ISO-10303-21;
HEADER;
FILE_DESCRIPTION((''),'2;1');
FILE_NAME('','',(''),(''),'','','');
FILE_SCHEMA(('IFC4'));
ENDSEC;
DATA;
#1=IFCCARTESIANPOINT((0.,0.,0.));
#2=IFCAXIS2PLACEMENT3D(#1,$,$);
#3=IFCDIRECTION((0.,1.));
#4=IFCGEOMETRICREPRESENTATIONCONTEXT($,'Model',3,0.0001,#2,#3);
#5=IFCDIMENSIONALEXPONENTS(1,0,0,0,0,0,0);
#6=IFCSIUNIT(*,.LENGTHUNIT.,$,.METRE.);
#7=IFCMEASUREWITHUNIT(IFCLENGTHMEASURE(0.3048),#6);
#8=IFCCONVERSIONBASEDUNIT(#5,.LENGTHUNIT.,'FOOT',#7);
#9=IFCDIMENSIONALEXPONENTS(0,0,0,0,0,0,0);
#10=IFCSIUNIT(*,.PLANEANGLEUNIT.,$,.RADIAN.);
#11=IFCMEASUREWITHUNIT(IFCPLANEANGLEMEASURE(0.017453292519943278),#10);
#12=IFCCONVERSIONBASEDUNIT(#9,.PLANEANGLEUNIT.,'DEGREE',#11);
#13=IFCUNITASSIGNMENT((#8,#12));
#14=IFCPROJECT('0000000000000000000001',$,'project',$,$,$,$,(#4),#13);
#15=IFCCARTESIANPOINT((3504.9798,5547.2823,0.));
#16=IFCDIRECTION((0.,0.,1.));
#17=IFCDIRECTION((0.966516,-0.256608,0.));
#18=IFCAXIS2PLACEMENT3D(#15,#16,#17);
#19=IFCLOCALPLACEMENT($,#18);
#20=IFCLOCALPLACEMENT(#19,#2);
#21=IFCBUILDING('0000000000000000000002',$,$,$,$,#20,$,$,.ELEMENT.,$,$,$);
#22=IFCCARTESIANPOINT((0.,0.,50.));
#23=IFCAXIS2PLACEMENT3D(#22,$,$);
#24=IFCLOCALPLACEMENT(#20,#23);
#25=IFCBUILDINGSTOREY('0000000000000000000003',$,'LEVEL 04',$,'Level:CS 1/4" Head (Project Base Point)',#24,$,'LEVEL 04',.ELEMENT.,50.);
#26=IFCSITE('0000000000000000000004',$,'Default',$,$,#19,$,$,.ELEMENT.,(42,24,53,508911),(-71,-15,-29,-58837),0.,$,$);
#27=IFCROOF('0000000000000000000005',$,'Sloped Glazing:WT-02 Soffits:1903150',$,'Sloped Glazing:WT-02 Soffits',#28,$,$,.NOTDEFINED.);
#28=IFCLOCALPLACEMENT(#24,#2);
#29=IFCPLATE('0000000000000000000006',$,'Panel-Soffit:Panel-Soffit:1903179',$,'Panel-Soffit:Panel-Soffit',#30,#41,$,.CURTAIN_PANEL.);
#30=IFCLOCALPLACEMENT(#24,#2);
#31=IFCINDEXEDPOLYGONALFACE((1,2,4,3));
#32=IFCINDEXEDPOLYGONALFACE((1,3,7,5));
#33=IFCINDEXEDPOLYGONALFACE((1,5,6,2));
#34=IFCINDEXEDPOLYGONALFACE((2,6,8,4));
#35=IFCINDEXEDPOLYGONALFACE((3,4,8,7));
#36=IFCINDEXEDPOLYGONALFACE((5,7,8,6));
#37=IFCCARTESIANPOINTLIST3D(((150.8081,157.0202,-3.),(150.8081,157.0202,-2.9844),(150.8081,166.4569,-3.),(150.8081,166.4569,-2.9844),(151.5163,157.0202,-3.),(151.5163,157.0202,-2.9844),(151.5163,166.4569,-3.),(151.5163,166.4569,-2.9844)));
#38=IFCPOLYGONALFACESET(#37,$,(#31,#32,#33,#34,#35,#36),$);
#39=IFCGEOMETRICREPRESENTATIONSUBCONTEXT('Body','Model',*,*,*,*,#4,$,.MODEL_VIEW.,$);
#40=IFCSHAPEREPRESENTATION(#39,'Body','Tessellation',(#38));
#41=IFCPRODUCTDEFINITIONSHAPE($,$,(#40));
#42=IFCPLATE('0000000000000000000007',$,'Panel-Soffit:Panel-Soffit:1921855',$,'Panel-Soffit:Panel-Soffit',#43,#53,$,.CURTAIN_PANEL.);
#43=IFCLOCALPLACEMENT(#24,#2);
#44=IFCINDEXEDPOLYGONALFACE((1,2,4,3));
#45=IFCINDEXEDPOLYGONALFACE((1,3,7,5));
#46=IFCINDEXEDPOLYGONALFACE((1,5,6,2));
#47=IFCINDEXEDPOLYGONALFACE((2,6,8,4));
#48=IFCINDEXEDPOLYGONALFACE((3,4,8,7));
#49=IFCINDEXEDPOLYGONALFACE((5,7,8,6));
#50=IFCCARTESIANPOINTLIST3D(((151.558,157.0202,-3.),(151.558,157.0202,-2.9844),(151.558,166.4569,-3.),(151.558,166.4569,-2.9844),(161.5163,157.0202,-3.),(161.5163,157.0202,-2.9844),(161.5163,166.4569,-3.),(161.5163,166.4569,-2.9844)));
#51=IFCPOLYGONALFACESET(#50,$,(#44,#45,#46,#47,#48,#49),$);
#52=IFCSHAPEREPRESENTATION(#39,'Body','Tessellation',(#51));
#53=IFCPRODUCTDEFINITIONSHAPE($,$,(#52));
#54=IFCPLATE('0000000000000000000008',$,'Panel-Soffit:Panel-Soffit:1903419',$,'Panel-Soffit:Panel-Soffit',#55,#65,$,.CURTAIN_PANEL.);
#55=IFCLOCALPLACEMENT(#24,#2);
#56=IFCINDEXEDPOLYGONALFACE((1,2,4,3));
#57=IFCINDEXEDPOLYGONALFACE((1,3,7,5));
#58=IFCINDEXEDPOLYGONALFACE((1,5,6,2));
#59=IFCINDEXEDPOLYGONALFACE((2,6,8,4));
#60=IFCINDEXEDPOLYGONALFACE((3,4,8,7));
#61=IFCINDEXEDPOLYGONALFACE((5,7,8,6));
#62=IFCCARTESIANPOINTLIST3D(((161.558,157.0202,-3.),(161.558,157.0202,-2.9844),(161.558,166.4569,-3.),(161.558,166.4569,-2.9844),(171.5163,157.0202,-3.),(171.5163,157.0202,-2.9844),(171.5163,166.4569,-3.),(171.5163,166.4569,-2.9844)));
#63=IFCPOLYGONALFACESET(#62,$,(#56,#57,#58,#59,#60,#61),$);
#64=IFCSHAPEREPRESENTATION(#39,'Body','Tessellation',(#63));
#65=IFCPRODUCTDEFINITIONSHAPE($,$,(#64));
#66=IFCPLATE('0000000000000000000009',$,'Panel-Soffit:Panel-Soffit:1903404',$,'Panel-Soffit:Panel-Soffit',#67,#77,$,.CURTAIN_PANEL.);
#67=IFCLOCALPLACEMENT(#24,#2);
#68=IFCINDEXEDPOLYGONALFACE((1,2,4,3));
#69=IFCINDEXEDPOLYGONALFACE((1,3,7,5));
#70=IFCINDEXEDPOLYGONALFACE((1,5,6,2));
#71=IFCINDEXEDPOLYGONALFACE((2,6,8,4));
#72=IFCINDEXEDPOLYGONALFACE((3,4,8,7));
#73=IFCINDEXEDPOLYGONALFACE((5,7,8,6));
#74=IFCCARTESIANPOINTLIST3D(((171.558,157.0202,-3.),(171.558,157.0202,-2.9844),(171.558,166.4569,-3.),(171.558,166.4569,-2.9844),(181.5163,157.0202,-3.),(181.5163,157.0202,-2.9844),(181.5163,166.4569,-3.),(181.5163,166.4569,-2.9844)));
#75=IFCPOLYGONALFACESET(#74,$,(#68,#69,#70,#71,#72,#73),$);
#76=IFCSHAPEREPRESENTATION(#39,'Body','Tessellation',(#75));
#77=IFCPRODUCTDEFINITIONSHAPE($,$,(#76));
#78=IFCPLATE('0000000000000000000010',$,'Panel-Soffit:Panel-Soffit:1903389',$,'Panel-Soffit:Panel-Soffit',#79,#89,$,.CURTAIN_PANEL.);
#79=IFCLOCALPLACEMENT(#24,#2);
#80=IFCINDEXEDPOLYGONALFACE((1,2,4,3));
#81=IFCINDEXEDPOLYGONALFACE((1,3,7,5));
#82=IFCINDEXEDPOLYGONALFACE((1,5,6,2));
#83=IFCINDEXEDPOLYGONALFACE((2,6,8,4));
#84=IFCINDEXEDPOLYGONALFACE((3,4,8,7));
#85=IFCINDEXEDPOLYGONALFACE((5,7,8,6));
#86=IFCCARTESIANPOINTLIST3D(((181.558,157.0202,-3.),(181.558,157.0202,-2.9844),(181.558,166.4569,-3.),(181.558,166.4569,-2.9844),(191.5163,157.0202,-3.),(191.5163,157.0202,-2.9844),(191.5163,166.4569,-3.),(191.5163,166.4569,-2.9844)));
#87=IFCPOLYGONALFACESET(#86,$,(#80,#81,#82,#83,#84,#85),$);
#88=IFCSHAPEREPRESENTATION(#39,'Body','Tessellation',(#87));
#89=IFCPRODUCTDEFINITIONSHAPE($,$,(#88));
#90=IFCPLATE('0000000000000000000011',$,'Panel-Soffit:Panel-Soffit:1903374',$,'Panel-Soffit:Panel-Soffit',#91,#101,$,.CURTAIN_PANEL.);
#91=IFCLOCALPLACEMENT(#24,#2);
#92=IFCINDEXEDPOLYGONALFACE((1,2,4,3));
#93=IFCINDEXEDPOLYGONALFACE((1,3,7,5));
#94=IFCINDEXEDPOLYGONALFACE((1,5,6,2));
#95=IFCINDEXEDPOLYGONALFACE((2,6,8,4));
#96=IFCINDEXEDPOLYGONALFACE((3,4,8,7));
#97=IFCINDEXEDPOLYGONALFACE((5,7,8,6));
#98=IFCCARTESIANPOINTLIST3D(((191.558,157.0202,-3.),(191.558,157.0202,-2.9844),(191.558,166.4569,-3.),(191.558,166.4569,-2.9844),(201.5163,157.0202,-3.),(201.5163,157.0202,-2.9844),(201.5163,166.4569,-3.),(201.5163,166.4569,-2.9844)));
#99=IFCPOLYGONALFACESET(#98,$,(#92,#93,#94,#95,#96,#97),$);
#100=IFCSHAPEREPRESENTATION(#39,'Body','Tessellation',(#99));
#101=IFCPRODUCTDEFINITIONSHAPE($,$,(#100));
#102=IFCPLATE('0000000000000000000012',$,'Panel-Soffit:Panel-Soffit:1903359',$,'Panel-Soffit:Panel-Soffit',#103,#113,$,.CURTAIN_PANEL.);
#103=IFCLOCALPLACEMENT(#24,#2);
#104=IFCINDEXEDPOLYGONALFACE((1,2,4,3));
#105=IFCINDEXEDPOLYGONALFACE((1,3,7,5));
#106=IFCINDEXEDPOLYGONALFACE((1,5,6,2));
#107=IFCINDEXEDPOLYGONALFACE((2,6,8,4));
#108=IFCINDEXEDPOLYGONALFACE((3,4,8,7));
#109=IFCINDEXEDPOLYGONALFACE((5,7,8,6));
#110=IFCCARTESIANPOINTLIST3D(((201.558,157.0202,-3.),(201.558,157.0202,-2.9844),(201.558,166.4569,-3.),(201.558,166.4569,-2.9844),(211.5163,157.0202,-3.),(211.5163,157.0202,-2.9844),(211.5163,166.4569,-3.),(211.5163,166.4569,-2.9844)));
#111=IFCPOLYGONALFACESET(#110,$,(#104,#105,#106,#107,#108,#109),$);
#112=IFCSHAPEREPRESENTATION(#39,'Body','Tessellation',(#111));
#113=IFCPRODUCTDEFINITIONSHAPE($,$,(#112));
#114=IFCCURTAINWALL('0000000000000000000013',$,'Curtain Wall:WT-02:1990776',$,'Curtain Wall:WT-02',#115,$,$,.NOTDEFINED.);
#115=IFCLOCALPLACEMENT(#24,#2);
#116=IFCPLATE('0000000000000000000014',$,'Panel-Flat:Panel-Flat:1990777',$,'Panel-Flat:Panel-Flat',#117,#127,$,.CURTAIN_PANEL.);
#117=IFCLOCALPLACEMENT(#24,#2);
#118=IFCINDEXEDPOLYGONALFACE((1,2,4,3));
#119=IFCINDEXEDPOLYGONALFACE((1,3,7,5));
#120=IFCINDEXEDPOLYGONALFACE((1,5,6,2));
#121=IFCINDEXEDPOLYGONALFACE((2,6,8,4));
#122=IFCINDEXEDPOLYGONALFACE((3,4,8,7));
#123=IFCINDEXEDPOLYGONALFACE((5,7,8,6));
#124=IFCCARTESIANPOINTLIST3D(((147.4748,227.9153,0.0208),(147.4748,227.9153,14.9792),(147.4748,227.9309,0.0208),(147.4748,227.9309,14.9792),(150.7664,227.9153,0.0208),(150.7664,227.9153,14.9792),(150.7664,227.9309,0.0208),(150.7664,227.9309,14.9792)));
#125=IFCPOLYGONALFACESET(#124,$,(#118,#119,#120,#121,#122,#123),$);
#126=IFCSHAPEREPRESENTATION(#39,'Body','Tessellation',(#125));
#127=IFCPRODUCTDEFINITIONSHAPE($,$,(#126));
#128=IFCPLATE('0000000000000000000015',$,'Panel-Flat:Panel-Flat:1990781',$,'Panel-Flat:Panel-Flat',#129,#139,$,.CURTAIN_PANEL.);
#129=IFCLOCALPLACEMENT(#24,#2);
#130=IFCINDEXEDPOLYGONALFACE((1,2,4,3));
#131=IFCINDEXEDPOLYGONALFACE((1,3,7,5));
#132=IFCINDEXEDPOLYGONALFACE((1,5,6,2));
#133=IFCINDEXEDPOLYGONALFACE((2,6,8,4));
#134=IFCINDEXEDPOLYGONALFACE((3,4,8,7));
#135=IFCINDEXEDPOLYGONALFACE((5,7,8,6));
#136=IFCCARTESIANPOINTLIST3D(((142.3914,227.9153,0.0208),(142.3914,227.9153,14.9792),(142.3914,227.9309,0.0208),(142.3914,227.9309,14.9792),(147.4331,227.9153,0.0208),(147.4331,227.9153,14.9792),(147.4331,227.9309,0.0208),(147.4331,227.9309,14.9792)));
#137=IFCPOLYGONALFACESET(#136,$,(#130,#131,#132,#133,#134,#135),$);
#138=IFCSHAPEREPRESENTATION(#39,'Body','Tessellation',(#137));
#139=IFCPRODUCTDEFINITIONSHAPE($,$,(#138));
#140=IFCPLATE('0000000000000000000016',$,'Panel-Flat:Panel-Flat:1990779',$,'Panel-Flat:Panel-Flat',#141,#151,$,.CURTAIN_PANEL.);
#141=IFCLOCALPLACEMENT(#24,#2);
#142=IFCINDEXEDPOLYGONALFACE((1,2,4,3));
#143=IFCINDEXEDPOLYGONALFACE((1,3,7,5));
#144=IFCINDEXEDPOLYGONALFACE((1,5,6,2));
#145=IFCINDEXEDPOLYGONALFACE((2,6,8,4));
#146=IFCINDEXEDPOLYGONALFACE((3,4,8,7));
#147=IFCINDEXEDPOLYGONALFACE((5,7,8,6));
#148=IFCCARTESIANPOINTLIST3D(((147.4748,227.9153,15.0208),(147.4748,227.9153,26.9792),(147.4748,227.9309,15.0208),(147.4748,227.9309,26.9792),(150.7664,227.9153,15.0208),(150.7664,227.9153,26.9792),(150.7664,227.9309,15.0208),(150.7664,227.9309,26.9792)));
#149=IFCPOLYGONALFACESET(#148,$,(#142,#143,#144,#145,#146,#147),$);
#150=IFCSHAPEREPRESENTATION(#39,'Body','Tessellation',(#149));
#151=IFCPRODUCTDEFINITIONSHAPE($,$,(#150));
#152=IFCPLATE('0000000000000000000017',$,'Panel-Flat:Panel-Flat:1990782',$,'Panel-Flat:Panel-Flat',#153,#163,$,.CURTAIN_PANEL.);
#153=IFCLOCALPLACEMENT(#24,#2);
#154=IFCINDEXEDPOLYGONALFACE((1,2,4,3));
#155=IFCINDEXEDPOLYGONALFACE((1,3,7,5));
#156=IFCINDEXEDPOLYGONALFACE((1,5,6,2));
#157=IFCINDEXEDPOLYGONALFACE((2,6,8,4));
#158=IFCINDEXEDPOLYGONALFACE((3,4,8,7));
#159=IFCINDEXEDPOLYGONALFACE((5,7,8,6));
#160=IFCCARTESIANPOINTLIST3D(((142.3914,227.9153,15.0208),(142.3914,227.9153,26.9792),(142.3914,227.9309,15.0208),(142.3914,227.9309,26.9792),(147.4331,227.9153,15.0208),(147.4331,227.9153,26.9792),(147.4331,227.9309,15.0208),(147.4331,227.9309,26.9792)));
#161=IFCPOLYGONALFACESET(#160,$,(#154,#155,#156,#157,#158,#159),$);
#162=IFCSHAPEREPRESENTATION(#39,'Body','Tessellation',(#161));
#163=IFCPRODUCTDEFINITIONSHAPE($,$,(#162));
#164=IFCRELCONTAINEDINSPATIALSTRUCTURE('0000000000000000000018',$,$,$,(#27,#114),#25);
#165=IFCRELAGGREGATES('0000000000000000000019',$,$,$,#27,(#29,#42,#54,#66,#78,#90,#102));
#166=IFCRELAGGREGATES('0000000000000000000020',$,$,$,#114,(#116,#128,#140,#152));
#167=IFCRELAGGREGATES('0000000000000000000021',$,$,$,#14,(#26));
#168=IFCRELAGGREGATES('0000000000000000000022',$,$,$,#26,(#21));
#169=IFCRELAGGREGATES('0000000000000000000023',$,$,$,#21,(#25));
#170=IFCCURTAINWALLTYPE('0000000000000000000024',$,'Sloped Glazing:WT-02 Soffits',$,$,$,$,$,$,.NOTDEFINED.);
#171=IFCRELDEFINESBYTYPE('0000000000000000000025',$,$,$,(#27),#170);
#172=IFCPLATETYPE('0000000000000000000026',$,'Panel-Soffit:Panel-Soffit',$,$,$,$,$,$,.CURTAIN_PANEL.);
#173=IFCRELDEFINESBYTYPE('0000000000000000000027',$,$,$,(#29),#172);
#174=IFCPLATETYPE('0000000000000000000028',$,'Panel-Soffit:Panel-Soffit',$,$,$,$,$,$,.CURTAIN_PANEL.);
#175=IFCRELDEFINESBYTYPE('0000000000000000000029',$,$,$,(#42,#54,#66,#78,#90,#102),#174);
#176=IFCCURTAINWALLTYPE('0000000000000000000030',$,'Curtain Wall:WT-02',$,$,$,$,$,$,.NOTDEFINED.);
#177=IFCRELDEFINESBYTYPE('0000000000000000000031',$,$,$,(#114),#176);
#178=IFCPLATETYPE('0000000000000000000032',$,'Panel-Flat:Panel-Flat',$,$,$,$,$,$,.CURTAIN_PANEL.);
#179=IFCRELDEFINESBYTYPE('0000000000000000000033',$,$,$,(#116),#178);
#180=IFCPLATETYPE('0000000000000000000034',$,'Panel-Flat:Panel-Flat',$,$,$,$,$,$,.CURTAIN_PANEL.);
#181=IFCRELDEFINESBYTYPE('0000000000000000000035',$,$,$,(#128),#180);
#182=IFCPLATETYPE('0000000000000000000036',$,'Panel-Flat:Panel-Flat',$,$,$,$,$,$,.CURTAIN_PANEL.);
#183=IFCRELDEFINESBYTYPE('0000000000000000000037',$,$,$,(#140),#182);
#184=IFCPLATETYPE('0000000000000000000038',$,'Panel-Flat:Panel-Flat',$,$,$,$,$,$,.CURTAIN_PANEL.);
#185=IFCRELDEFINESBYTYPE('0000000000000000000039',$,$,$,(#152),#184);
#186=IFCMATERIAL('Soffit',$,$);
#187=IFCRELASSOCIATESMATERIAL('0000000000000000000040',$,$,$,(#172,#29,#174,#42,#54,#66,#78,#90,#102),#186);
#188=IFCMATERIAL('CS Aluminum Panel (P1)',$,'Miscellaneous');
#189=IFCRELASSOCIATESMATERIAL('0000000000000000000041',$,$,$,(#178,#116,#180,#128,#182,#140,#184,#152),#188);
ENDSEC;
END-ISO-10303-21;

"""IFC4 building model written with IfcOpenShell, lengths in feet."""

from ifc_helpers import new_model, entity, si_unit, converted_unit, direction, frame, origin, place, context, subcontext, project, spatial, indexed_curve, outline, extrude, source, transform, mapped, material, type_object, type_shapes, element, aggregate, save


model = new_model("IFC4")

# Units and contexts
model_context = context("Model", 3, precision=0.0001, world=origin(), true_north=direction((0.0, 1.0)))
body_context = subcontext(model_context, "Body", "Model", "MODEL_VIEW")
ifc_project = project(units=[converted_unit("LENGTHUNIT", "FOOT", entity("IfcLengthMeasure", 0.3048), si_unit("LENGTHUNIT", "METRE"), dimensions=[1, 0, 0, 0, 0, 0, 0]), converted_unit("PLANEANGLEUNIT", "DEGREE", entity("IfcPlaneAngleMeasure", 0.017453292519943278), si_unit("PLANEANGLEUNIT", "RADIAN"), dimensions=[0, 0, 0, 0, 0, 0, 0])], contexts=[model_context])

# Site, building, storey
site_placement = place(None, frame((3504.9798, 5547.2823, 0.0), z_axis=(0.0, 0.0, 1.0), x_axis=(0.966516, -0.256608, 0.0)))
site = spatial("IfcSite", under=ifc_project, at=site_placement, Name="Default", CompositionType="ELEMENT", RefLatitude=(42, 24, 53, 508911), RefLongitude=(-71, -15, -29, -58837), RefElevation=0.0)
building_placement = place(site_placement, origin())
building = spatial("IfcBuilding", under=site, at=building_placement, CompositionType="ELEMENT")
storey_placement = place(building_placement, frame((0.0, 0.0, 50.0)))
storey = spatial("IfcBuildingStorey", under=building, at=storey_placement, Name="LEVEL 04", ObjectType="Level:CS 1/4\" Head (Project Base Point)", LongName="LEVEL 04", CompositionType="ELEMENT", Elevation=50.0)

# Roof, plates
curtain_wall_type_1 = type_object("IfcCurtainWallType", Name="Sloped Glazing:WT-02 Soffits", PredefinedType="NOTDEFINED")
roof_placement = place(storey_placement, frame((0.0, 0.0, -50.0)))
roof = element("IfcRoof", 1, at=roof_placement, inside=storey, type_object=curtain_wall_type_1, Name="Sloped Glazing:WT-02 Soffits:1903150", ObjectType="Sloped Glazing:WT-02 Soffits", PredefinedType="NOTDEFINED")
ifc_material_1 = material(Name="Soffit")
plate_type_1 = type_object("IfcPlateType", Name="Panel-Soffit:Panel-Soffit", PredefinedType="CURTAIN_PANEL", material=ifc_material_1)
shared_shape_1 = source(origin(), body_context, "Body", "SweptSolid", [
    extrude(outline(indexed_curve([(-0.0078, -0.3541), (0.0078, -0.3541), (0.0078, 0.3541), (-0.0078, 0.3541), (-0.0078, -0.3541)], self_intersect=False)), frame((0.0, -0.0078, 0.0208), z_axis=(0.0, 0.0, 1.0), x_axis=(0.0, -1.0, 0.0)), (0.0, 0.0, 1.0), 9.4367),
])
type_shapes(plate_type_1, [shared_shape_1])
plate_1_placement = place(roof_placement, frame((151.1622, 156.9993, 47.0), z_axis=(0.0, 1.0, 0.0), x_axis=(1.0, 0.0, 0.0)))
plate_1 = element("IfcPlate", 2, at=plate_1_placement, type_object=plate_type_1, material=ifc_material_1, Name="Panel-Soffit:Panel-Soffit:1903179", ObjectType="Panel-Soffit:Panel-Soffit", PredefinedType="CURTAIN_PANEL", context=body_context, shape_type="MappedRepresentation", body=[
    mapped(shared_shape_1, transform((0.0, 0.0, 0.0), scale=1.0)),
])
plate_type_2 = type_object("IfcPlateType", Name="Panel-Soffit:Panel-Soffit", PredefinedType="CURTAIN_PANEL", material=ifc_material_1)
shared_shape_2 = source(origin(), body_context, "Body", "SweptSolid", [
    extrude(outline(indexed_curve([(-0.0078, -4.9792), (0.0078, -4.9792), (0.0078, 4.9792), (-0.0078, 4.9792), (-0.0078, -4.9792)], self_intersect=False)), frame((0.0, -0.0078, 0.0208), z_axis=(0.0, 0.0, 1.0), x_axis=(0.0, -1.0, 0.0)), (0.0, 0.0, 1.0), 9.4367),
])
type_shapes(plate_type_2, [shared_shape_2])
plate_2_placement = place(roof_placement, frame((156.5372, 156.9993, 47.0), z_axis=(0.0, 1.0, 0.0), x_axis=(1.0, 0.0, 0.0)))
plate_2 = element("IfcPlate", 3, at=plate_2_placement, type_object=plate_type_2, material=ifc_material_1, Name="Panel-Soffit:Panel-Soffit:1921855", ObjectType="Panel-Soffit:Panel-Soffit", PredefinedType="CURTAIN_PANEL", context=body_context, shape_type="MappedRepresentation", body=[
    mapped(shared_shape_2, transform((0.0, 0.0, 0.0), scale=1.0)),
])
plate_3_placement = place(roof_placement, frame((166.5372, 156.9993, 47.0), z_axis=(0.0, 1.0, 0.0), x_axis=(1.0, 0.0, 0.0)))
plate_3 = element("IfcPlate", 4, at=plate_3_placement, type_object=plate_type_2, material=ifc_material_1, Name="Panel-Soffit:Panel-Soffit:1903419", ObjectType="Panel-Soffit:Panel-Soffit", PredefinedType="CURTAIN_PANEL", context=body_context, shape_type="MappedRepresentation", body=[
    mapped(shared_shape_2, transform((0.0, 0.0, 0.0), scale=1.0)),
])
plate_4_placement = place(roof_placement, frame((176.5372, 156.9993, 47.0), z_axis=(0.0, 1.0, 0.0), x_axis=(1.0, 0.0, 0.0)))
plate_4 = element("IfcPlate", 5, at=plate_4_placement, type_object=plate_type_2, material=ifc_material_1, Name="Panel-Soffit:Panel-Soffit:1903404", ObjectType="Panel-Soffit:Panel-Soffit", PredefinedType="CURTAIN_PANEL", context=body_context, shape_type="MappedRepresentation", body=[
    mapped(shared_shape_2, transform((0.0, 0.0, 0.0), scale=1.0)),
])
plate_5_placement = place(roof_placement, frame((186.5372, 156.9993, 47.0), z_axis=(0.0, 1.0, 0.0), x_axis=(1.0, 0.0, 0.0)))
plate_5 = element("IfcPlate", 6, at=plate_5_placement, type_object=plate_type_2, material=ifc_material_1, Name="Panel-Soffit:Panel-Soffit:1903389", ObjectType="Panel-Soffit:Panel-Soffit", PredefinedType="CURTAIN_PANEL", context=body_context, shape_type="MappedRepresentation", body=[
    mapped(shared_shape_2, transform((0.0, 0.0, 0.0), scale=1.0)),
])
plate_6_placement = place(roof_placement, frame((196.5372, 156.9993, 47.0), z_axis=(0.0, 1.0, 0.0), x_axis=(1.0, 0.0, 0.0)))
plate_6 = element("IfcPlate", 7, at=plate_6_placement, type_object=plate_type_2, material=ifc_material_1, Name="Panel-Soffit:Panel-Soffit:1903374", ObjectType="Panel-Soffit:Panel-Soffit", PredefinedType="CURTAIN_PANEL", context=body_context, shape_type="MappedRepresentation", body=[
    mapped(shared_shape_2, transform((0.0, 0.0, 0.0), scale=1.0)),
])
plate_7_placement = place(roof_placement, frame((206.5372, 156.9993, 47.0), z_axis=(0.0, 1.0, 0.0), x_axis=(1.0, 0.0, 0.0)))
plate_7 = element("IfcPlate", 8, at=plate_7_placement, type_object=plate_type_2, material=ifc_material_1, Name="Panel-Soffit:Panel-Soffit:1903359", ObjectType="Panel-Soffit:Panel-Soffit", PredefinedType="CURTAIN_PANEL", context=body_context, shape_type="MappedRepresentation", body=[
    mapped(shared_shape_2, transform((0.0, 0.0, 0.0), scale=1.0)),
])
aggregate(roof, [plate_1, plate_2, plate_3, plate_4, plate_5, plate_6, plate_7])

# Shared definitions
curtain_wall_type_2 = type_object("IfcCurtainWallType", Name="Curtain Wall:WT-02", PredefinedType="NOTDEFINED")

# Curtain wall, plates
curtain_wall_1_placement = place(storey_placement, frame((0.0, 0.0, -50.0)))
curtain_wall_1 = element("IfcCurtainWall", 9, at=curtain_wall_1_placement, inside=storey, type_object=curtain_wall_type_2, Name="Curtain Wall:WT-02:1990776", ObjectType="Curtain Wall:WT-02", PredefinedType="NOTDEFINED")
ifc_material_2 = material(Name="CS Aluminum Panel (P1)", Category="Miscellaneous")
plate_type_3 = type_object("IfcPlateType", Name="Panel-Flat:Panel-Flat", PredefinedType="CURTAIN_PANEL", material=ifc_material_2)
shared_shape_3 = source(origin(), body_context, "Body", "SweptSolid", [
    extrude(outline(indexed_curve([(-0.0078, -1.6458), (0.0078, -1.6458), (0.0078, 1.6458), (-0.0078, 1.6458), (-0.0078, -1.6458)], self_intersect=False)), frame((0.0, -0.0078, 0.0208), z_axis=(0.0, 0.0, 1.0), x_axis=(0.0, -1.0, 0.0)), (0.0, 0.0, 1.0), 14.9583),
])
type_shapes(plate_type_3, [shared_shape_3])
plate_8_placement = place(curtain_wall_1_placement, frame((149.1206, 227.9153, 50.0), z_axis=(0.0, 0.0, 1.0), x_axis=(-1.0, 0.0, 0.0)))
plate_8 = element("IfcPlate", 10, at=plate_8_placement, type_object=plate_type_3, material=ifc_material_2, Name="Panel-Flat:Panel-Flat:1990777", ObjectType="Panel-Flat:Panel-Flat", PredefinedType="CURTAIN_PANEL", context=body_context, shape_type="MappedRepresentation", body=[
    mapped(shared_shape_3, transform((0.0, 0.0, 0.0), scale=1.0)),
])
plate_type_4 = type_object("IfcPlateType", Name="Panel-Flat:Panel-Flat", PredefinedType="CURTAIN_PANEL", material=ifc_material_2)
shared_shape_4 = source(origin(), body_context, "Body", "SweptSolid", [
    extrude(outline(indexed_curve([(-0.0078, -2.5208), (0.0078, -2.5208), (0.0078, 2.5208), (-0.0078, 2.5208), (-0.0078, -2.5208)], self_intersect=False)), frame((0.0, -0.0078, 0.0208), z_axis=(0.0, 0.0, 1.0), x_axis=(0.0, -1.0, 0.0)), (0.0, 0.0, 1.0), 14.9583),
])
type_shapes(plate_type_4, [shared_shape_4])
plate_9_placement = place(curtain_wall_1_placement, frame((144.9123, 227.9153, 50.0), z_axis=(0.0, 0.0, 1.0), x_axis=(-1.0, 0.0, 0.0)))
plate_9 = element("IfcPlate", 11, at=plate_9_placement, type_object=plate_type_4, material=ifc_material_2, Name="Panel-Flat:Panel-Flat:1990781", ObjectType="Panel-Flat:Panel-Flat", PredefinedType="CURTAIN_PANEL", context=body_context, shape_type="MappedRepresentation", body=[
    mapped(shared_shape_4, transform((0.0, 0.0, 0.0), scale=1.0)),
])
plate_type_5 = type_object("IfcPlateType", Name="Panel-Flat:Panel-Flat", PredefinedType="CURTAIN_PANEL", material=ifc_material_2)
shared_shape_5 = source(origin(), body_context, "Body", "SweptSolid", [
    extrude(outline(indexed_curve([(-0.0078, -1.6458), (0.0078, -1.6458), (0.0078, 1.6458), (-0.0078, 1.6458), (-0.0078, -1.6458)], self_intersect=False)), frame((0.0, -0.0078, 0.0208), z_axis=(0.0, 0.0, 1.0), x_axis=(0.0, -1.0, 0.0)), (0.0, 0.0, 1.0), 11.9583),
])
type_shapes(plate_type_5, [shared_shape_5])
plate_10_placement = place(curtain_wall_1_placement, frame((149.1206, 227.9153, 65.0), z_axis=(0.0, 0.0, 1.0), x_axis=(-1.0, 0.0, 0.0)))
plate_10 = element("IfcPlate", 12, at=plate_10_placement, type_object=plate_type_5, material=ifc_material_2, Name="Panel-Flat:Panel-Flat:1990779", ObjectType="Panel-Flat:Panel-Flat", PredefinedType="CURTAIN_PANEL", context=body_context, shape_type="MappedRepresentation", body=[
    mapped(shared_shape_5, transform((0.0, 0.0, 0.0), scale=1.0)),
])
plate_type_6 = type_object("IfcPlateType", Name="Panel-Flat:Panel-Flat", PredefinedType="CURTAIN_PANEL", material=ifc_material_2)
shared_shape_6 = source(origin(), body_context, "Body", "SweptSolid", [
    extrude(outline(indexed_curve([(-0.0078, -2.5208), (0.0078, -2.5208), (0.0078, 2.5208), (-0.0078, 2.5208), (-0.0078, -2.5208)], self_intersect=False)), frame((0.0, -0.0078, 0.0208), z_axis=(0.0, 0.0, 1.0), x_axis=(0.0, -1.0, 0.0)), (0.0, 0.0, 1.0), 11.9583),
])
type_shapes(plate_type_6, [shared_shape_6])
plate_11_placement = place(curtain_wall_1_placement, frame((144.9123, 227.9153, 65.0), z_axis=(0.0, 0.0, 1.0), x_axis=(-1.0, 0.0, 0.0)))
plate_11 = element("IfcPlate", 13, at=plate_11_placement, type_object=plate_type_6, material=ifc_material_2, Name="Panel-Flat:Panel-Flat:1990782", ObjectType="Panel-Flat:Panel-Flat", PredefinedType="CURTAIN_PANEL", context=body_context, shape_type="MappedRepresentation", body=[
    mapped(shared_shape_6, transform((0.0, 0.0, 0.0), scale=1.0)),
])
aggregate(curtain_wall_1, [plate_8, plate_9, plate_10, plate_11])

save(model, "model.ifc")
